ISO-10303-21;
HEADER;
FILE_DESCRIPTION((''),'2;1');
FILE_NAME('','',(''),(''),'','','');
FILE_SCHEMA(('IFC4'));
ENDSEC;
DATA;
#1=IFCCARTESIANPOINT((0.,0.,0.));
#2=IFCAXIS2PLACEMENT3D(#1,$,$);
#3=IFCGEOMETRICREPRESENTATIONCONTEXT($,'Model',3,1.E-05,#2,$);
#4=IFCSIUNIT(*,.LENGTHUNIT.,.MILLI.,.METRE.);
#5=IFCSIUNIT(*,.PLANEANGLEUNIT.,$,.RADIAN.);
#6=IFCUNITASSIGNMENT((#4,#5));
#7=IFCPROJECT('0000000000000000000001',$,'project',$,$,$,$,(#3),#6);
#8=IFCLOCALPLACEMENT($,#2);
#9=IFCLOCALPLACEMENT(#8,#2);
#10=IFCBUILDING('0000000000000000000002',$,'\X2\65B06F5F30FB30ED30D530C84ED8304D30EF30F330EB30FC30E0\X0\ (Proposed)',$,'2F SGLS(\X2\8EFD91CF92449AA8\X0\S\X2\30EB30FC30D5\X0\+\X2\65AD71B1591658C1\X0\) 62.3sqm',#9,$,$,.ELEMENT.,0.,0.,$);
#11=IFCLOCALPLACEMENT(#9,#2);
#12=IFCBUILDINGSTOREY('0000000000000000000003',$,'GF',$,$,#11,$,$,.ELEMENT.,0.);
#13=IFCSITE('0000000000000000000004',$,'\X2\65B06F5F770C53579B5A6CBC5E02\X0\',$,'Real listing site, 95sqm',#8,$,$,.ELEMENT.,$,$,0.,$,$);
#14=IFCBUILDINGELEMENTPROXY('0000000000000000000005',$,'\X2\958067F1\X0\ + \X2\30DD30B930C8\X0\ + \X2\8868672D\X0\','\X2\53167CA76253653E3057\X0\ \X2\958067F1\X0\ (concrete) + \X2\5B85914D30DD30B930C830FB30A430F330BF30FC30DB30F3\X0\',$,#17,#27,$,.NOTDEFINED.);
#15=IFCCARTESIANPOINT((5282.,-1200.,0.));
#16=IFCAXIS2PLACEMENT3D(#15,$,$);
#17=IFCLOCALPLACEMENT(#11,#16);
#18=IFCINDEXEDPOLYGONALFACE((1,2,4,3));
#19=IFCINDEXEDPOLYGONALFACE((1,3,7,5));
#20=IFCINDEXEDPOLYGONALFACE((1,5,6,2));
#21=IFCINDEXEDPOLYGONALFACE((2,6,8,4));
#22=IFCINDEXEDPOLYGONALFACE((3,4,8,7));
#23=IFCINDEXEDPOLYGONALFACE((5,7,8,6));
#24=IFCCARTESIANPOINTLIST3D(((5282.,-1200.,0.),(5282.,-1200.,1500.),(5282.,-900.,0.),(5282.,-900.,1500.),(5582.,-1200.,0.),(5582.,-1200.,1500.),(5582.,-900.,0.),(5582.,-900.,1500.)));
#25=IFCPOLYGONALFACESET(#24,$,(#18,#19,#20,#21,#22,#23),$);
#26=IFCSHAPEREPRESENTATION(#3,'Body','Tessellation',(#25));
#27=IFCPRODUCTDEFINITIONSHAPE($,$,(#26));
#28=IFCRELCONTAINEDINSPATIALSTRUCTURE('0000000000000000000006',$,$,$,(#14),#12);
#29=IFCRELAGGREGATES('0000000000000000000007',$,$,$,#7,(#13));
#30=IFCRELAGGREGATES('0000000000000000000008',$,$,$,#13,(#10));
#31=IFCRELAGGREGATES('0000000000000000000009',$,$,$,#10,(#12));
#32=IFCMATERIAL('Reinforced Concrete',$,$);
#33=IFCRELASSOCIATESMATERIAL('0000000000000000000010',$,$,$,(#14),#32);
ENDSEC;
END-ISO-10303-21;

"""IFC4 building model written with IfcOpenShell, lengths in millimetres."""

from ifc_helpers import new_model, si_unit, frame, frame_2d, origin, place, context, project, spatial, rectangle, extrude, material, element, save


model = new_model("IFC4")

# Units and contexts
model_context = context("Model", 3, precision=1e-05, world=origin())
ifc_project = project(units=[si_unit("LENGTHUNIT", "METRE", prefix="MILLI"), si_unit("PLANEANGLEUNIT", "RADIAN")], contexts=[model_context])

# Site, building, storey
site_placement = place(None, origin())
site = spatial("IfcSite", under=ifc_project, at=site_placement, Name="新潟県南魚沼市", ObjectType="Real listing site, 95sqm", CompositionType="ELEMENT", RefElevation=0.0)
building_placement = place(site_placement, origin())
building = spatial("IfcBuilding", under=site, at=building_placement, Name="新潟・ロフト付きワンルーム (Proposed)", ObjectType="2F SGLS(軽量鉄骨Sルーフ+断熱外壁) 62.3sqm", CompositionType="ELEMENT", ElevationOfRefHeight=0.0, ElevationOfTerrain=0.0)
storey_placement = place(building_placement, origin())
storey = spatial("IfcBuildingStorey", under=building, at=storey_placement, Name="GF", CompositionType="ELEMENT", Elevation=0.0)

# Shared definitions
ifc_material_1 = material(Name="Reinforced Concrete")

# Building element proxy
proxy_placement = place(storey_placement, frame((5282.0, -1200.0, 0.0)))
element("IfcBuildingElementProxy", 1, at=proxy_placement, inside=storey, material=ifc_material_1, Name="門柱 + ポスト + 表札", Description="化粧打放し 門柱 (concrete) + 宅配ポスト・インターホン", PredefinedType="NOTDEFINED", context=model_context, shape_type="SweptSolid", body=[
    extrude(rectangle(XDim=300.0, YDim=300.0, at=frame_2d((150.0, 150.0))), frame((5282.0, -1200.0, 0.0)), (0.0, 0.0, 1.0), 1500.0),
])

save(model, "model.ifc")
